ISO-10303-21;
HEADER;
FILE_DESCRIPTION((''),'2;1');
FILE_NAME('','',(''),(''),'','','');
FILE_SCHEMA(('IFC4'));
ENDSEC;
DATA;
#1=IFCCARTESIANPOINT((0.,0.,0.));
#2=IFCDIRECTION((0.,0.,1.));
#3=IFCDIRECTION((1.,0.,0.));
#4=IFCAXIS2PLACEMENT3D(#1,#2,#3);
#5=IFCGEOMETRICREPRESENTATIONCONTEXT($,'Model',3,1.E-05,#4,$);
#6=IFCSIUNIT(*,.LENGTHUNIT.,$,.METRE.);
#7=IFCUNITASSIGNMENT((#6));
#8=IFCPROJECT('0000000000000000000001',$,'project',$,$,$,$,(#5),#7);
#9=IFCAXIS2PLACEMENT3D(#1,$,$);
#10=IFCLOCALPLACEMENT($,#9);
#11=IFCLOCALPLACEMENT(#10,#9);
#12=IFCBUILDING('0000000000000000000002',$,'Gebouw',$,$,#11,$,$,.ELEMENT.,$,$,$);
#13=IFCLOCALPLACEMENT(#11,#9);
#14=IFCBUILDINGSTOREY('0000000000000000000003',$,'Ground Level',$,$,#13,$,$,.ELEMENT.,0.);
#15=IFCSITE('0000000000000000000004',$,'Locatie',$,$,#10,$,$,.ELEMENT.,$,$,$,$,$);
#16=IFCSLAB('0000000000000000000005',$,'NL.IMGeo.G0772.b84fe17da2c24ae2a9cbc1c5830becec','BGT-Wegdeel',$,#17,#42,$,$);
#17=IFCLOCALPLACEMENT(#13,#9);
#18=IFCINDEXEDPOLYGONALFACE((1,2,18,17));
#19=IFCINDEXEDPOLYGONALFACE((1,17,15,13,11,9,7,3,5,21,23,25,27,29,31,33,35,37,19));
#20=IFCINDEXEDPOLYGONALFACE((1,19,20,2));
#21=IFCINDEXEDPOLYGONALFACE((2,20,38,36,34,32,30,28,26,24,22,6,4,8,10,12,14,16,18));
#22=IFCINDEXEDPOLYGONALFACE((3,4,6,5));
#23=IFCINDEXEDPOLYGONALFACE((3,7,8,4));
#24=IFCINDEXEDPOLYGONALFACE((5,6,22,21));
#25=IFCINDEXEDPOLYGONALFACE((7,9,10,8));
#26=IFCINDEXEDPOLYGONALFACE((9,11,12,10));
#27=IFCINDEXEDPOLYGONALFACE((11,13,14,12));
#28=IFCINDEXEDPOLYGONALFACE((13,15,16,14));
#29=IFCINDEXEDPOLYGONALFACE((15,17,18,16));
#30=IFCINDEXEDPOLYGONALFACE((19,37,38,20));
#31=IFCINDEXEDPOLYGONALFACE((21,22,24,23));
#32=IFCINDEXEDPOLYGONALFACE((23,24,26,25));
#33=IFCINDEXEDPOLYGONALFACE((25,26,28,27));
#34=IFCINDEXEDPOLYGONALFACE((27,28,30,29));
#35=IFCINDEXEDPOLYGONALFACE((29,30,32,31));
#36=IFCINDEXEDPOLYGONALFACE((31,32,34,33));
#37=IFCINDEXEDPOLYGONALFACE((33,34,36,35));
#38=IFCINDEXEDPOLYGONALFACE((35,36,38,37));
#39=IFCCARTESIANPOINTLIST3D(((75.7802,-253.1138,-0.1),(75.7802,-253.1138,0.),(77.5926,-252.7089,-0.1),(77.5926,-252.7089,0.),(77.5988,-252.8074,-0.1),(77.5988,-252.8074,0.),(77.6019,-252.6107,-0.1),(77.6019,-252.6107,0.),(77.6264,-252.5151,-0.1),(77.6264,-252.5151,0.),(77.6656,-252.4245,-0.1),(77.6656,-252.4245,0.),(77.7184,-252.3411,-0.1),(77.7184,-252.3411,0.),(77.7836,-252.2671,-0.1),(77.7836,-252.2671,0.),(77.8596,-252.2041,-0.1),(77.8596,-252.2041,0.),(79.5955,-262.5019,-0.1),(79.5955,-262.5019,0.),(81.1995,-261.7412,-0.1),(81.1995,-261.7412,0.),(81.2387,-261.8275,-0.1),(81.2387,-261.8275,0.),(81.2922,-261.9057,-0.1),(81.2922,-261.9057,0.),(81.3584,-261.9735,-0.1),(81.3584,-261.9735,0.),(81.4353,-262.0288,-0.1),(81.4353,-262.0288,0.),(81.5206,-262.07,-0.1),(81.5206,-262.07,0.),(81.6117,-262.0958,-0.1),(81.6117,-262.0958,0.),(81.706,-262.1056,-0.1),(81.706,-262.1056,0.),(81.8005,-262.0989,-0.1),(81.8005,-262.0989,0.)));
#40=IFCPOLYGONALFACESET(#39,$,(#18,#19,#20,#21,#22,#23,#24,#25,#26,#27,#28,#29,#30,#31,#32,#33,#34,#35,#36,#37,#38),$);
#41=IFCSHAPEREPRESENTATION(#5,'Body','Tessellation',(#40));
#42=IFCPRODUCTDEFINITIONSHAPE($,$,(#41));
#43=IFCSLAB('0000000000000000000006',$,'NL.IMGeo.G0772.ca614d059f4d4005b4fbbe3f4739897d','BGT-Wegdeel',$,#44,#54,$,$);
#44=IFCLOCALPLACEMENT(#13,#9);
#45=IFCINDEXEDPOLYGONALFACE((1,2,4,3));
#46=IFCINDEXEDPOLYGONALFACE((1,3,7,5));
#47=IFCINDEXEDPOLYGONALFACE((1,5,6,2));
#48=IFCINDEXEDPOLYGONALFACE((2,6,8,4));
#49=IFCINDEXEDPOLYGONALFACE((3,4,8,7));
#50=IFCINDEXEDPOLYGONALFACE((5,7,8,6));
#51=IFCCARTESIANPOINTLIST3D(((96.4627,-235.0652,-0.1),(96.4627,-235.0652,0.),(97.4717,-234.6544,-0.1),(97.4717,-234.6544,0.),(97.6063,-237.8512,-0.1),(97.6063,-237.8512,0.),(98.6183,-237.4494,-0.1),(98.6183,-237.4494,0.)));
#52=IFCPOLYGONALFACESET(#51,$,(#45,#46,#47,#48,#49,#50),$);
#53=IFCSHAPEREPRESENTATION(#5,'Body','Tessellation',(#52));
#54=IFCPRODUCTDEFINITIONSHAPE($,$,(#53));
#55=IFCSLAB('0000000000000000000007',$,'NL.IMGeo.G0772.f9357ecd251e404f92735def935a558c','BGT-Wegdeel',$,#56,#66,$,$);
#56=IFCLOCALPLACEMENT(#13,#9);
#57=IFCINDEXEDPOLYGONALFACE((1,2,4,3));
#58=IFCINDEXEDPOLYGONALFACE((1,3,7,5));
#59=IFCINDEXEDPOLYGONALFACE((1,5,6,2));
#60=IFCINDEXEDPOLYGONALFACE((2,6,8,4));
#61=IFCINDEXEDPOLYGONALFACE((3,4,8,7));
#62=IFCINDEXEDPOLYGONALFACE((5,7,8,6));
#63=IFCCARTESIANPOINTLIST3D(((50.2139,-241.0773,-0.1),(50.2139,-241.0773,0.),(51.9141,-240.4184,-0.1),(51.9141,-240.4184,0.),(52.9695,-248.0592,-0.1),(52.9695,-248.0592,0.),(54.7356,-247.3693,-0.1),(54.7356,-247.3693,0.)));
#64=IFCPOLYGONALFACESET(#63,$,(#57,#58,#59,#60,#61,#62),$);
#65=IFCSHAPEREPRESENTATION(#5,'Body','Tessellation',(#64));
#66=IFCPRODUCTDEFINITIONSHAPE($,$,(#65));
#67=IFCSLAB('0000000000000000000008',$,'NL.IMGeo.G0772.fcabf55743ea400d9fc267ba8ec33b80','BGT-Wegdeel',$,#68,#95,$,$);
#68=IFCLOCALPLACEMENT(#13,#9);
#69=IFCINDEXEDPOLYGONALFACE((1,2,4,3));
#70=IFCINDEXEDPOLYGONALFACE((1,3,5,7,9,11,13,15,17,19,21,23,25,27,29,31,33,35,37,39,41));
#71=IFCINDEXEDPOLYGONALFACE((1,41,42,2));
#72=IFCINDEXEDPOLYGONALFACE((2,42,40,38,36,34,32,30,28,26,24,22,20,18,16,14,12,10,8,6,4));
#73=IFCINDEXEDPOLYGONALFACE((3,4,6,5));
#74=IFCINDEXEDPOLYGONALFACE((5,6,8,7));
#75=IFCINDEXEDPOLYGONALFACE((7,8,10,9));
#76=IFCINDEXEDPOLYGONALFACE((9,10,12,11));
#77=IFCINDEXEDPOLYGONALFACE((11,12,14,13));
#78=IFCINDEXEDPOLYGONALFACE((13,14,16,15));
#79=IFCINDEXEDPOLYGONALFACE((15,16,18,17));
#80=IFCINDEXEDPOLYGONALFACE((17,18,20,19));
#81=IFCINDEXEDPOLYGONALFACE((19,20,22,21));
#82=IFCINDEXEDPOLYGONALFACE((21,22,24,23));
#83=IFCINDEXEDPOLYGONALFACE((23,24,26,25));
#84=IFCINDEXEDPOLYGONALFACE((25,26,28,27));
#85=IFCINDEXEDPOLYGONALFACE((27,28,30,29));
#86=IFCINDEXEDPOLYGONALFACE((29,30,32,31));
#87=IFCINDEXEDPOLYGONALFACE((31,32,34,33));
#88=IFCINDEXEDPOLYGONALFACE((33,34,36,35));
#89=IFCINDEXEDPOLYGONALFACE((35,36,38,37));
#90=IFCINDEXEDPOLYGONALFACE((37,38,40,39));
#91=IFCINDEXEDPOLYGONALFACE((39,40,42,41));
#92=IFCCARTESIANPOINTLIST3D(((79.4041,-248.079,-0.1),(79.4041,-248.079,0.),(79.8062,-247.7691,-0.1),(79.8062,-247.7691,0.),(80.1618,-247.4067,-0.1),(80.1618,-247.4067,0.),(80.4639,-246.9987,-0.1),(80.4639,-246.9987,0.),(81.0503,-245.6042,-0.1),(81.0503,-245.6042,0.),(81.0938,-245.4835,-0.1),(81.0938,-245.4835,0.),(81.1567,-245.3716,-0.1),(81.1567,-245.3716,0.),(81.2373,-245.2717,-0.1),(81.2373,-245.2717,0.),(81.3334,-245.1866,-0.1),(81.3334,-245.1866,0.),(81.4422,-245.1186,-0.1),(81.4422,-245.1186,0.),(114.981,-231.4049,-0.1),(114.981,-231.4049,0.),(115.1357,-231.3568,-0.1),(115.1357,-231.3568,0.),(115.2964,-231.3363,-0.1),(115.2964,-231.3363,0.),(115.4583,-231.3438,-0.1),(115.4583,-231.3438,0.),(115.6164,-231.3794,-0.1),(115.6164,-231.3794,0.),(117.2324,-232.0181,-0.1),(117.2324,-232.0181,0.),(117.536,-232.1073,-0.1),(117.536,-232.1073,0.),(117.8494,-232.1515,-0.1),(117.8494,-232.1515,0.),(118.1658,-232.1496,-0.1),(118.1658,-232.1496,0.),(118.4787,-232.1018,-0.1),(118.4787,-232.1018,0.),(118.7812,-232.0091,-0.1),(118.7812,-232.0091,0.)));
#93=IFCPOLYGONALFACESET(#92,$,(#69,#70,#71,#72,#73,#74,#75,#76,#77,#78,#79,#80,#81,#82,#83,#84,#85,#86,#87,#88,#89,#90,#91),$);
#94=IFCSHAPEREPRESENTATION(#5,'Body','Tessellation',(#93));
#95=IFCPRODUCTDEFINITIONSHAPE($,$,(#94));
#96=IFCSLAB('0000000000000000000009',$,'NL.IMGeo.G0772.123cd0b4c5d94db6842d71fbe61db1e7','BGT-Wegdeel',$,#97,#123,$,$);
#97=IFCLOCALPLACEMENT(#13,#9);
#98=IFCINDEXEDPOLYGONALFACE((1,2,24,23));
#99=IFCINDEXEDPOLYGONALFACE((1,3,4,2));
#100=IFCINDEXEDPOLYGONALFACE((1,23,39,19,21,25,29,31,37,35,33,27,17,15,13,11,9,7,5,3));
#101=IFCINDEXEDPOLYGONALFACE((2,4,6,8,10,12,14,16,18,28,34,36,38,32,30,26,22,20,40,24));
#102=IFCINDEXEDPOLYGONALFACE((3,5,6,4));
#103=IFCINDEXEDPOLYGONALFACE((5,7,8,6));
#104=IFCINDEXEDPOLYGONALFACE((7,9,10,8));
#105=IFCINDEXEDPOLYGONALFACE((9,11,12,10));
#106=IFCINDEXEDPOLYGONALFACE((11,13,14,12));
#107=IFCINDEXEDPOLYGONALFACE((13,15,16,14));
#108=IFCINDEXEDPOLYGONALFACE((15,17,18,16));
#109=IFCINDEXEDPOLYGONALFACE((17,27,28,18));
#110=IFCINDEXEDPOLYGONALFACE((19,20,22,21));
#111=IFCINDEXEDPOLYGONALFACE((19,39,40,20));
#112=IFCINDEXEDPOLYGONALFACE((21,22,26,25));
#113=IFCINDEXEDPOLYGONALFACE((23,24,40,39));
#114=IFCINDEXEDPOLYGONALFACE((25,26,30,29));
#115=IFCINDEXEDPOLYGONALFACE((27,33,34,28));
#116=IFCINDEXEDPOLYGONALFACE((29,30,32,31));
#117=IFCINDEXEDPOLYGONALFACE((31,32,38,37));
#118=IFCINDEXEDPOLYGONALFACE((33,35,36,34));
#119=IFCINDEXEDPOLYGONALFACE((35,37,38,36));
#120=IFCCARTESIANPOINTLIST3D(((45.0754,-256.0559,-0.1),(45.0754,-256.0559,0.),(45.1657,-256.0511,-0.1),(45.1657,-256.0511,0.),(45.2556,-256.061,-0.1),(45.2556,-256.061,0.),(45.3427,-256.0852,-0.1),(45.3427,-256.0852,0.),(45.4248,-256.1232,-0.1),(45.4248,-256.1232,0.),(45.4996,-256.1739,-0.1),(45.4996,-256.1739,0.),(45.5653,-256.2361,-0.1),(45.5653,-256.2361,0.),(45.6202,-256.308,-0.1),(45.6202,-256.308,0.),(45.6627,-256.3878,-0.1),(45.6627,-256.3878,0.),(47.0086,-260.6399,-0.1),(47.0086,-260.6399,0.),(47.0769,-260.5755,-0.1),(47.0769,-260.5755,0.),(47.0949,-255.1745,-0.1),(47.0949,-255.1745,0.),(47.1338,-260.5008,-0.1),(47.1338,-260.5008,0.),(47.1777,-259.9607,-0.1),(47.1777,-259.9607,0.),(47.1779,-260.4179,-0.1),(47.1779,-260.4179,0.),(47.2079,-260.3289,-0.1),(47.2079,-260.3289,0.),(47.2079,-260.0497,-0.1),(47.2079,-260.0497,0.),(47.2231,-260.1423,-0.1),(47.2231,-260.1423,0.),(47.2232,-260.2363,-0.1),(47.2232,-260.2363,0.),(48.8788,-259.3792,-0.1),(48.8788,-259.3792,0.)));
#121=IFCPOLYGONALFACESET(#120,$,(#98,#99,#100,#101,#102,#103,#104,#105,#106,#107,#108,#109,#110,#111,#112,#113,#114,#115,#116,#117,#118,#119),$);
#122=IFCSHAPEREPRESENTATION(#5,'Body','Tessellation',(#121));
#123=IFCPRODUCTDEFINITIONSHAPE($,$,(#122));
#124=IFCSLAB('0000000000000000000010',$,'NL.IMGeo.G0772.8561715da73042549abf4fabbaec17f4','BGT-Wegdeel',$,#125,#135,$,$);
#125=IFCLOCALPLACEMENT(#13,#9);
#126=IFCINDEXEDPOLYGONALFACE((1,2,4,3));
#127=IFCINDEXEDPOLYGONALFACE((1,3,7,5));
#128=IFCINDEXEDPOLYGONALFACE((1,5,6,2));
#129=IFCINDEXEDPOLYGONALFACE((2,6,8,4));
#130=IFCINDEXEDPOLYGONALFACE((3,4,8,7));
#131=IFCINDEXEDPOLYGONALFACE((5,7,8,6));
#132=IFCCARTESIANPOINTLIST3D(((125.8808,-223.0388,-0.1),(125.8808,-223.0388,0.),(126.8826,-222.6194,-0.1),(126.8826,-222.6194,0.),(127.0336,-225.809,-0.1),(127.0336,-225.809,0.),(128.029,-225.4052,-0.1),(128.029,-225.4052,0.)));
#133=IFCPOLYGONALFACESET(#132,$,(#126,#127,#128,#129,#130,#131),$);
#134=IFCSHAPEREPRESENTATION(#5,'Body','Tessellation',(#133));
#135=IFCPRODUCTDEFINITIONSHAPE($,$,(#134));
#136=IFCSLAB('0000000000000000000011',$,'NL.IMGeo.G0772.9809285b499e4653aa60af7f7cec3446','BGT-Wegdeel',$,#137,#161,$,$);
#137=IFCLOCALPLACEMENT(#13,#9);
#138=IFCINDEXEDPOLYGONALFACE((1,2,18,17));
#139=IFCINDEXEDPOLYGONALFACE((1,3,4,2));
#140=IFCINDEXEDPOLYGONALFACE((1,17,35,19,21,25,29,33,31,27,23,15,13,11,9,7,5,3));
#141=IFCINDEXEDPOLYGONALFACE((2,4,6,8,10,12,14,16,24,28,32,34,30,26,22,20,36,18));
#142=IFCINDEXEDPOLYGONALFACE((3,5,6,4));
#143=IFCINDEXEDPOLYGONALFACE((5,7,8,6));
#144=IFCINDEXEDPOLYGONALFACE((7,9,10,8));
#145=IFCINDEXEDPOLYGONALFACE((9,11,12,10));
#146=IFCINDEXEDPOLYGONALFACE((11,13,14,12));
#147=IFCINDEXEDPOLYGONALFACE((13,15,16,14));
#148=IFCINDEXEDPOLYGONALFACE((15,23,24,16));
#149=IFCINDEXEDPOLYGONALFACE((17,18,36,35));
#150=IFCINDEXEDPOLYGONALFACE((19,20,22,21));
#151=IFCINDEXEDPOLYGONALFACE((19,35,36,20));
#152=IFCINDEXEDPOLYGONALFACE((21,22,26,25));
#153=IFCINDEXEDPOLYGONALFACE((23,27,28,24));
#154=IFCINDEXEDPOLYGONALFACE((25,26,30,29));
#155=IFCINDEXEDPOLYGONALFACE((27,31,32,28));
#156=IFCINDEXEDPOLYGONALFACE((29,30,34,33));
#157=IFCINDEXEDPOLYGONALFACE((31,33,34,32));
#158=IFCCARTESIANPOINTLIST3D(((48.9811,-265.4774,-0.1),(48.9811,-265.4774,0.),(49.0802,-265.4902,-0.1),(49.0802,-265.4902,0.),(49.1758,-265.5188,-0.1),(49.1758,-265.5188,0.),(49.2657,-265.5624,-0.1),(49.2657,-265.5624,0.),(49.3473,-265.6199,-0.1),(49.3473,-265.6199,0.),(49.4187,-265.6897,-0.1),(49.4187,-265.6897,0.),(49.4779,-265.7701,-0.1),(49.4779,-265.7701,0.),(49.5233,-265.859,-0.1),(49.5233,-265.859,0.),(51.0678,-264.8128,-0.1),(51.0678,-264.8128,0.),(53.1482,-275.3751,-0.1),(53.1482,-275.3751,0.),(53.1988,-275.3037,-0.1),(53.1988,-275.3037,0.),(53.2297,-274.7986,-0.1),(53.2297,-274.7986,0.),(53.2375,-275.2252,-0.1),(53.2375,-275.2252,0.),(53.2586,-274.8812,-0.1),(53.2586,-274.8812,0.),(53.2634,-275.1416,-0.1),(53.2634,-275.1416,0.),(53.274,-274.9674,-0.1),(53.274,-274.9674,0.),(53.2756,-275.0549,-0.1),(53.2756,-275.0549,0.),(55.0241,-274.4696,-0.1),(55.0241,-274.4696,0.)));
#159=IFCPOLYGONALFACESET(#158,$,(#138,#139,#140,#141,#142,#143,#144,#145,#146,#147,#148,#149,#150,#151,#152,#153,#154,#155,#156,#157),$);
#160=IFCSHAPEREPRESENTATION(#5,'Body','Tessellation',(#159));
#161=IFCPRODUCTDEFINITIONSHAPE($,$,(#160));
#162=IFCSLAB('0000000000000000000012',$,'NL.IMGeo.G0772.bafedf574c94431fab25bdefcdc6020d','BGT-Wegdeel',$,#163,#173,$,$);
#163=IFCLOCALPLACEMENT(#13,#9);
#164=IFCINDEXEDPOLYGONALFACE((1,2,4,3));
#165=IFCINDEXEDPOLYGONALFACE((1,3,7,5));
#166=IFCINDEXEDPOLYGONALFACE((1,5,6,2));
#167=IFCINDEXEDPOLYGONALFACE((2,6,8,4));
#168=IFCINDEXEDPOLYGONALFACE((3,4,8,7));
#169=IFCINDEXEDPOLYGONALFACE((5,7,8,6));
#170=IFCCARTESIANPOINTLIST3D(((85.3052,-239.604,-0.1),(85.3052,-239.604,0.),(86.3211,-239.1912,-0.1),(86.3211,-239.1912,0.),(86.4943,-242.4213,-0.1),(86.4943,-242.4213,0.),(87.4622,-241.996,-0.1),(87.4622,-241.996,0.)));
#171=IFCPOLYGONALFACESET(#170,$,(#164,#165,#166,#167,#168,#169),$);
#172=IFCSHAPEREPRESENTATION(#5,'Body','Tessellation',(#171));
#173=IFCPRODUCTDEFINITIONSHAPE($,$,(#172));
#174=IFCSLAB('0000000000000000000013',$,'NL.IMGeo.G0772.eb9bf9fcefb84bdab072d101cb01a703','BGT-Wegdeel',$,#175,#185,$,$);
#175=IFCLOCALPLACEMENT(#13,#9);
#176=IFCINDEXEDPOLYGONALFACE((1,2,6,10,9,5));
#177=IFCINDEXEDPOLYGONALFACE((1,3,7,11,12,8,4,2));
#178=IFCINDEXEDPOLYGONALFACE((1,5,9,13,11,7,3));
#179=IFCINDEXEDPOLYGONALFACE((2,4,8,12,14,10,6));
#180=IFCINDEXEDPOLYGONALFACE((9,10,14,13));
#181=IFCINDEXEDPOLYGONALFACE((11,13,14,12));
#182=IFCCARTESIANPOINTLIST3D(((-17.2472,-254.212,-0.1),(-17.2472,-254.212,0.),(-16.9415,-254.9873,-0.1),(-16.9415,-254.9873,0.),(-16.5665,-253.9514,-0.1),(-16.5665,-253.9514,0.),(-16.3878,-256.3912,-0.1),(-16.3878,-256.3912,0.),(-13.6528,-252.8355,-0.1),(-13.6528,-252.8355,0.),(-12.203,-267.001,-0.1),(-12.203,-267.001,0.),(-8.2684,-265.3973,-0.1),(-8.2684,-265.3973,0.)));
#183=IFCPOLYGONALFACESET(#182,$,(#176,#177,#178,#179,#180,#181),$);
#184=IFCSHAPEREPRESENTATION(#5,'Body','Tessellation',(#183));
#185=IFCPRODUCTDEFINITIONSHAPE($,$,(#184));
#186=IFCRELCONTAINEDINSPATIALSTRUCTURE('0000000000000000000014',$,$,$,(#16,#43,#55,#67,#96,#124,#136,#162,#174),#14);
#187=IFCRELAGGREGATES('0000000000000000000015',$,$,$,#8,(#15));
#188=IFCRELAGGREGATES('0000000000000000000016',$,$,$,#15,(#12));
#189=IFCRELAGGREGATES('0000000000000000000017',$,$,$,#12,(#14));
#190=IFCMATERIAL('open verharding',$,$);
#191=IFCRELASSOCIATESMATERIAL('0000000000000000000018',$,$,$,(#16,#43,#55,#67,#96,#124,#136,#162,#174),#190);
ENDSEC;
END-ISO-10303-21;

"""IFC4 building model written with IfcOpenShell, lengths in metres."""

from ifc_helpers import new_model, si_unit, frame, origin, origin_with_axes, place, context, project, spatial, polyline, outline, extrude, material, element, save


model = new_model("IFC4")

# Units and contexts
model_context = context("Model", 3, precision=1e-05, world=origin_with_axes())
ifc_project = project(units=[si_unit("LENGTHUNIT", "METRE")], contexts=[model_context])

# Site, building, storey
site_placement = place(None, origin())
site = spatial("IfcSite", under=ifc_project, at=site_placement, Name="Locatie", CompositionType="ELEMENT")
building_placement = place(site_placement, origin())
building = spatial("IfcBuilding", under=site, at=building_placement, Name="Gebouw", CompositionType="ELEMENT")
storey_placement = place(building_placement, origin())
storey = spatial("IfcBuildingStorey", under=building, at=storey_placement, Name="Ground Level", CompositionType="ELEMENT", Elevation=0.0)

# Slabs
ifc_material_1 = material(Name="open verharding")
slab_1_placement = place(storey_placement, origin())
element("IfcSlab", 1, at=slab_1_placement, inside=storey, material=ifc_material_1, Name="NL.IMGeo.G0772.b84fe17da2c24ae2a9cbc1c5830becec", Description="BGT-Wegdeel", context=model_context, shape_type="SweptSolid", body=[
    extrude(outline(polyline([(77.7836, -252.2671), (77.7184, -252.3411), (77.6656, -252.4245), (77.6264, -252.5151), (77.6019, -252.6107), (77.5926, -252.7089), (77.5988, -252.8074), (81.1995, -261.7412), (81.2387, -261.8275), (81.2922, -261.9057), (81.3584, -261.9735), (81.4353, -262.0288), (81.5206, -262.07), (81.6117, -262.0958), (81.706, -262.1056), (81.8005, -262.0989), (79.5955, -262.5019), (75.7802, -253.1138), (77.8596, -252.2041), (77.7836, -252.2671)])), frame((0.0, 0.0, -0.1), z_axis=(0.0, 0.0, 1.0), x_axis=(1.0, 0.0, 0.0)), (0.0, 0.0, 1.0), 0.1),
])
slab_2_placement = place(storey_placement, origin())
element("IfcSlab", 2, at=slab_2_placement, inside=storey, material=ifc_material_1, Name="NL.IMGeo.G0772.ca614d059f4d4005b4fbbe3f4739897d", Description="BGT-Wegdeel", context=model_context, shape_type="SweptSolid", body=[
    extrude(outline(polyline([(97.6063, -237.8512), (96.4627, -235.0652), (97.4717, -234.6544), (98.6183, -237.4494), (97.6063, -237.8512)])), frame((0.0, 0.0, -0.1), z_axis=(0.0, 0.0, 1.0), x_axis=(1.0, 0.0, 0.0)), (0.0, 0.0, 1.0), 0.1),
])
slab_3_placement = place(storey_placement, origin())
element("IfcSlab", 3, at=slab_3_placement, inside=storey, material=ifc_material_1, Name="NL.IMGeo.G0772.f9357ecd251e404f92735def935a558c", Description="BGT-Wegdeel", context=model_context, shape_type="SweptSolid", body=[
    extrude(outline(polyline([(54.7356, -247.3693), (52.9695, -248.0592), (50.2139, -241.0773), (51.9141, -240.4184), (54.7356, -247.3693)])), frame((0.0, 0.0, -0.1), z_axis=(0.0, 0.0, 1.0), x_axis=(1.0, 0.0, 0.0)), (0.0, 0.0, 1.0), 0.1),
])
slab_4_placement = place(storey_placement, origin())
element("IfcSlab", 4, at=slab_4_placement, inside=storey, material=ifc_material_1, Name="NL.IMGeo.G0772.fcabf55743ea400d9fc267ba8ec33b80", Description="BGT-Wegdeel", context=model_context, shape_type="SweptSolid", body=[
    extrude(outline(polyline([(81.0938, -245.4835), (81.1567, -245.3716), (81.2373, -245.2717), (81.3334, -245.1866), (81.4422, -245.1186), (114.981, -231.4049), (115.1357, -231.3568), (115.2964, -231.3363), (115.4583, -231.3438), (115.6164, -231.3794), (117.2324, -232.0181), (117.536, -232.1073), (117.8494, -232.1515), (118.1658, -232.1496), (118.4787, -232.1018), (118.7812, -232.0091), (79.4041, -248.079), (79.8062, -247.7691), (80.1618, -247.4067), (80.4639, -246.9987), (81.0503, -245.6042), (81.0938, -245.4835)])), frame((0.0, 0.0, -0.1), z_axis=(0.0, 0.0, 1.0), x_axis=(1.0, 0.0, 0.0)), (0.0, 0.0, 1.0), 0.1),
])
slab_5_placement = place(storey_placement, origin())
element("IfcSlab", 5, at=slab_5_placement, inside=storey, material=ifc_material_1, Name="NL.IMGeo.G0772.123cd0b4c5d94db6842d71fbe61db1e7", Description="BGT-Wegdeel", context=model_context, shape_type="SweptSolid", body=[
    extrude(outline(polyline([(45.6202, -256.308), (45.5653, -256.2361), (45.4996, -256.1739), (45.4248, -256.1232), (45.3427, -256.0852), (45.2556, -256.061), (45.1657, -256.0511), (45.0754, -256.0559), (47.0949, -255.1745), (48.8788, -259.3792), (47.0086, -260.6399), (47.0769, -260.5755), (47.1338, -260.5008), (47.1779, -260.4179), (47.2079, -260.3289), (47.2232, -260.2363), (47.2231, -260.1423), (47.2079, -260.0497), (47.1777, -259.9607), (45.6627, -256.3878), (45.6202, -256.308)])), frame((0.0, 0.0, -0.1), z_axis=(0.0, 0.0, 1.0), x_axis=(1.0, 0.0, 0.0)), (0.0, 0.0, 1.0), 0.1),
])
slab_6_placement = place(storey_placement, origin())
element("IfcSlab", 6, at=slab_6_placement, inside=storey, material=ifc_material_1, Name="NL.IMGeo.G0772.8561715da73042549abf4fabbaec17f4", Description="BGT-Wegdeel", context=model_context, shape_type="SweptSolid", body=[
    extrude(outline(polyline([(125.8808, -223.0388), (126.8826, -222.6194), (128.029, -225.4052), (127.0336, -225.809), (125.8808, -223.0388)])), frame((0.0, 0.0, -0.1), z_axis=(0.0, 0.0, 1.0), x_axis=(1.0, 0.0, 0.0)), (0.0, 0.0, 1.0), 0.1),
])
slab_7_placement = place(storey_placement, origin())
element("IfcSlab", 7, at=slab_7_placement, inside=storey, material=ifc_material_1, Name="NL.IMGeo.G0772.9809285b499e4653aa60af7f7cec3446", Description="BGT-Wegdeel", context=model_context, shape_type="SweptSolid", body=[
    extrude(outline(polyline([(49.5233, -265.859), (49.4779, -265.7701), (49.4187, -265.6897), (49.3473, -265.6199), (49.2657, -265.5624), (49.1758, -265.5188), (49.0802, -265.4902), (48.9811, -265.4774), (51.0678, -264.8128), (55.0241, -274.4696), (53.1482, -275.3751), (53.1988, -275.3037), (53.2375, -275.2252), (53.2634, -275.1416), (53.2756, -275.0549), (53.274, -274.9674), (53.2586, -274.8812), (53.2297, -274.7986), (49.5233, -265.859)])), frame((0.0, 0.0, -0.1), z_axis=(0.0, 0.0, 1.0), x_axis=(1.0, 0.0, 0.0)), (0.0, 0.0, 1.0), 0.1),
])
slab_8_placement = place(storey_placement, origin())
element("IfcSlab", 8, at=slab_8_placement, inside=storey, material=ifc_material_1, Name="NL.IMGeo.G0772.bafedf574c94431fab25bdefcdc6020d", Description="BGT-Wegdeel", context=model_context, shape_type="SweptSolid", body=[
    extrude(outline(polyline([(85.3052, -239.604), (86.3211, -239.1912), (87.4622, -241.996), (86.4943, -242.4213), (85.3052, -239.604)])), frame((0.0, 0.0, -0.1), z_axis=(0.0, 0.0, 1.0), x_axis=(1.0, 0.0, 0.0)), (0.0, 0.0, 1.0), 0.1),
])
slab_9_placement = place(storey_placement, origin())
element("IfcSlab", 9, at=slab_9_placement, inside=storey, material=ifc_material_1, Name="NL.IMGeo.G0772.eb9bf9fcefb84bdab072d101cb01a703", Description="BGT-Wegdeel", context=model_context, shape_type="SweptSolid", body=[
    extrude(outline(polyline([(-16.9415, -254.9873), (-17.2472, -254.212), (-16.5665, -253.9514), (-13.6528, -252.8355), (-8.2684, -265.3973), (-12.203, -267.001), (-16.3878, -256.3912), (-16.9415, -254.9873)])), frame((0.0, 0.0, -0.1), z_axis=(0.0, 0.0, 1.0), x_axis=(1.0, 0.0, 0.0)), (0.0, 0.0, 1.0), 0.1),
])

save(model, "model.ifc")
